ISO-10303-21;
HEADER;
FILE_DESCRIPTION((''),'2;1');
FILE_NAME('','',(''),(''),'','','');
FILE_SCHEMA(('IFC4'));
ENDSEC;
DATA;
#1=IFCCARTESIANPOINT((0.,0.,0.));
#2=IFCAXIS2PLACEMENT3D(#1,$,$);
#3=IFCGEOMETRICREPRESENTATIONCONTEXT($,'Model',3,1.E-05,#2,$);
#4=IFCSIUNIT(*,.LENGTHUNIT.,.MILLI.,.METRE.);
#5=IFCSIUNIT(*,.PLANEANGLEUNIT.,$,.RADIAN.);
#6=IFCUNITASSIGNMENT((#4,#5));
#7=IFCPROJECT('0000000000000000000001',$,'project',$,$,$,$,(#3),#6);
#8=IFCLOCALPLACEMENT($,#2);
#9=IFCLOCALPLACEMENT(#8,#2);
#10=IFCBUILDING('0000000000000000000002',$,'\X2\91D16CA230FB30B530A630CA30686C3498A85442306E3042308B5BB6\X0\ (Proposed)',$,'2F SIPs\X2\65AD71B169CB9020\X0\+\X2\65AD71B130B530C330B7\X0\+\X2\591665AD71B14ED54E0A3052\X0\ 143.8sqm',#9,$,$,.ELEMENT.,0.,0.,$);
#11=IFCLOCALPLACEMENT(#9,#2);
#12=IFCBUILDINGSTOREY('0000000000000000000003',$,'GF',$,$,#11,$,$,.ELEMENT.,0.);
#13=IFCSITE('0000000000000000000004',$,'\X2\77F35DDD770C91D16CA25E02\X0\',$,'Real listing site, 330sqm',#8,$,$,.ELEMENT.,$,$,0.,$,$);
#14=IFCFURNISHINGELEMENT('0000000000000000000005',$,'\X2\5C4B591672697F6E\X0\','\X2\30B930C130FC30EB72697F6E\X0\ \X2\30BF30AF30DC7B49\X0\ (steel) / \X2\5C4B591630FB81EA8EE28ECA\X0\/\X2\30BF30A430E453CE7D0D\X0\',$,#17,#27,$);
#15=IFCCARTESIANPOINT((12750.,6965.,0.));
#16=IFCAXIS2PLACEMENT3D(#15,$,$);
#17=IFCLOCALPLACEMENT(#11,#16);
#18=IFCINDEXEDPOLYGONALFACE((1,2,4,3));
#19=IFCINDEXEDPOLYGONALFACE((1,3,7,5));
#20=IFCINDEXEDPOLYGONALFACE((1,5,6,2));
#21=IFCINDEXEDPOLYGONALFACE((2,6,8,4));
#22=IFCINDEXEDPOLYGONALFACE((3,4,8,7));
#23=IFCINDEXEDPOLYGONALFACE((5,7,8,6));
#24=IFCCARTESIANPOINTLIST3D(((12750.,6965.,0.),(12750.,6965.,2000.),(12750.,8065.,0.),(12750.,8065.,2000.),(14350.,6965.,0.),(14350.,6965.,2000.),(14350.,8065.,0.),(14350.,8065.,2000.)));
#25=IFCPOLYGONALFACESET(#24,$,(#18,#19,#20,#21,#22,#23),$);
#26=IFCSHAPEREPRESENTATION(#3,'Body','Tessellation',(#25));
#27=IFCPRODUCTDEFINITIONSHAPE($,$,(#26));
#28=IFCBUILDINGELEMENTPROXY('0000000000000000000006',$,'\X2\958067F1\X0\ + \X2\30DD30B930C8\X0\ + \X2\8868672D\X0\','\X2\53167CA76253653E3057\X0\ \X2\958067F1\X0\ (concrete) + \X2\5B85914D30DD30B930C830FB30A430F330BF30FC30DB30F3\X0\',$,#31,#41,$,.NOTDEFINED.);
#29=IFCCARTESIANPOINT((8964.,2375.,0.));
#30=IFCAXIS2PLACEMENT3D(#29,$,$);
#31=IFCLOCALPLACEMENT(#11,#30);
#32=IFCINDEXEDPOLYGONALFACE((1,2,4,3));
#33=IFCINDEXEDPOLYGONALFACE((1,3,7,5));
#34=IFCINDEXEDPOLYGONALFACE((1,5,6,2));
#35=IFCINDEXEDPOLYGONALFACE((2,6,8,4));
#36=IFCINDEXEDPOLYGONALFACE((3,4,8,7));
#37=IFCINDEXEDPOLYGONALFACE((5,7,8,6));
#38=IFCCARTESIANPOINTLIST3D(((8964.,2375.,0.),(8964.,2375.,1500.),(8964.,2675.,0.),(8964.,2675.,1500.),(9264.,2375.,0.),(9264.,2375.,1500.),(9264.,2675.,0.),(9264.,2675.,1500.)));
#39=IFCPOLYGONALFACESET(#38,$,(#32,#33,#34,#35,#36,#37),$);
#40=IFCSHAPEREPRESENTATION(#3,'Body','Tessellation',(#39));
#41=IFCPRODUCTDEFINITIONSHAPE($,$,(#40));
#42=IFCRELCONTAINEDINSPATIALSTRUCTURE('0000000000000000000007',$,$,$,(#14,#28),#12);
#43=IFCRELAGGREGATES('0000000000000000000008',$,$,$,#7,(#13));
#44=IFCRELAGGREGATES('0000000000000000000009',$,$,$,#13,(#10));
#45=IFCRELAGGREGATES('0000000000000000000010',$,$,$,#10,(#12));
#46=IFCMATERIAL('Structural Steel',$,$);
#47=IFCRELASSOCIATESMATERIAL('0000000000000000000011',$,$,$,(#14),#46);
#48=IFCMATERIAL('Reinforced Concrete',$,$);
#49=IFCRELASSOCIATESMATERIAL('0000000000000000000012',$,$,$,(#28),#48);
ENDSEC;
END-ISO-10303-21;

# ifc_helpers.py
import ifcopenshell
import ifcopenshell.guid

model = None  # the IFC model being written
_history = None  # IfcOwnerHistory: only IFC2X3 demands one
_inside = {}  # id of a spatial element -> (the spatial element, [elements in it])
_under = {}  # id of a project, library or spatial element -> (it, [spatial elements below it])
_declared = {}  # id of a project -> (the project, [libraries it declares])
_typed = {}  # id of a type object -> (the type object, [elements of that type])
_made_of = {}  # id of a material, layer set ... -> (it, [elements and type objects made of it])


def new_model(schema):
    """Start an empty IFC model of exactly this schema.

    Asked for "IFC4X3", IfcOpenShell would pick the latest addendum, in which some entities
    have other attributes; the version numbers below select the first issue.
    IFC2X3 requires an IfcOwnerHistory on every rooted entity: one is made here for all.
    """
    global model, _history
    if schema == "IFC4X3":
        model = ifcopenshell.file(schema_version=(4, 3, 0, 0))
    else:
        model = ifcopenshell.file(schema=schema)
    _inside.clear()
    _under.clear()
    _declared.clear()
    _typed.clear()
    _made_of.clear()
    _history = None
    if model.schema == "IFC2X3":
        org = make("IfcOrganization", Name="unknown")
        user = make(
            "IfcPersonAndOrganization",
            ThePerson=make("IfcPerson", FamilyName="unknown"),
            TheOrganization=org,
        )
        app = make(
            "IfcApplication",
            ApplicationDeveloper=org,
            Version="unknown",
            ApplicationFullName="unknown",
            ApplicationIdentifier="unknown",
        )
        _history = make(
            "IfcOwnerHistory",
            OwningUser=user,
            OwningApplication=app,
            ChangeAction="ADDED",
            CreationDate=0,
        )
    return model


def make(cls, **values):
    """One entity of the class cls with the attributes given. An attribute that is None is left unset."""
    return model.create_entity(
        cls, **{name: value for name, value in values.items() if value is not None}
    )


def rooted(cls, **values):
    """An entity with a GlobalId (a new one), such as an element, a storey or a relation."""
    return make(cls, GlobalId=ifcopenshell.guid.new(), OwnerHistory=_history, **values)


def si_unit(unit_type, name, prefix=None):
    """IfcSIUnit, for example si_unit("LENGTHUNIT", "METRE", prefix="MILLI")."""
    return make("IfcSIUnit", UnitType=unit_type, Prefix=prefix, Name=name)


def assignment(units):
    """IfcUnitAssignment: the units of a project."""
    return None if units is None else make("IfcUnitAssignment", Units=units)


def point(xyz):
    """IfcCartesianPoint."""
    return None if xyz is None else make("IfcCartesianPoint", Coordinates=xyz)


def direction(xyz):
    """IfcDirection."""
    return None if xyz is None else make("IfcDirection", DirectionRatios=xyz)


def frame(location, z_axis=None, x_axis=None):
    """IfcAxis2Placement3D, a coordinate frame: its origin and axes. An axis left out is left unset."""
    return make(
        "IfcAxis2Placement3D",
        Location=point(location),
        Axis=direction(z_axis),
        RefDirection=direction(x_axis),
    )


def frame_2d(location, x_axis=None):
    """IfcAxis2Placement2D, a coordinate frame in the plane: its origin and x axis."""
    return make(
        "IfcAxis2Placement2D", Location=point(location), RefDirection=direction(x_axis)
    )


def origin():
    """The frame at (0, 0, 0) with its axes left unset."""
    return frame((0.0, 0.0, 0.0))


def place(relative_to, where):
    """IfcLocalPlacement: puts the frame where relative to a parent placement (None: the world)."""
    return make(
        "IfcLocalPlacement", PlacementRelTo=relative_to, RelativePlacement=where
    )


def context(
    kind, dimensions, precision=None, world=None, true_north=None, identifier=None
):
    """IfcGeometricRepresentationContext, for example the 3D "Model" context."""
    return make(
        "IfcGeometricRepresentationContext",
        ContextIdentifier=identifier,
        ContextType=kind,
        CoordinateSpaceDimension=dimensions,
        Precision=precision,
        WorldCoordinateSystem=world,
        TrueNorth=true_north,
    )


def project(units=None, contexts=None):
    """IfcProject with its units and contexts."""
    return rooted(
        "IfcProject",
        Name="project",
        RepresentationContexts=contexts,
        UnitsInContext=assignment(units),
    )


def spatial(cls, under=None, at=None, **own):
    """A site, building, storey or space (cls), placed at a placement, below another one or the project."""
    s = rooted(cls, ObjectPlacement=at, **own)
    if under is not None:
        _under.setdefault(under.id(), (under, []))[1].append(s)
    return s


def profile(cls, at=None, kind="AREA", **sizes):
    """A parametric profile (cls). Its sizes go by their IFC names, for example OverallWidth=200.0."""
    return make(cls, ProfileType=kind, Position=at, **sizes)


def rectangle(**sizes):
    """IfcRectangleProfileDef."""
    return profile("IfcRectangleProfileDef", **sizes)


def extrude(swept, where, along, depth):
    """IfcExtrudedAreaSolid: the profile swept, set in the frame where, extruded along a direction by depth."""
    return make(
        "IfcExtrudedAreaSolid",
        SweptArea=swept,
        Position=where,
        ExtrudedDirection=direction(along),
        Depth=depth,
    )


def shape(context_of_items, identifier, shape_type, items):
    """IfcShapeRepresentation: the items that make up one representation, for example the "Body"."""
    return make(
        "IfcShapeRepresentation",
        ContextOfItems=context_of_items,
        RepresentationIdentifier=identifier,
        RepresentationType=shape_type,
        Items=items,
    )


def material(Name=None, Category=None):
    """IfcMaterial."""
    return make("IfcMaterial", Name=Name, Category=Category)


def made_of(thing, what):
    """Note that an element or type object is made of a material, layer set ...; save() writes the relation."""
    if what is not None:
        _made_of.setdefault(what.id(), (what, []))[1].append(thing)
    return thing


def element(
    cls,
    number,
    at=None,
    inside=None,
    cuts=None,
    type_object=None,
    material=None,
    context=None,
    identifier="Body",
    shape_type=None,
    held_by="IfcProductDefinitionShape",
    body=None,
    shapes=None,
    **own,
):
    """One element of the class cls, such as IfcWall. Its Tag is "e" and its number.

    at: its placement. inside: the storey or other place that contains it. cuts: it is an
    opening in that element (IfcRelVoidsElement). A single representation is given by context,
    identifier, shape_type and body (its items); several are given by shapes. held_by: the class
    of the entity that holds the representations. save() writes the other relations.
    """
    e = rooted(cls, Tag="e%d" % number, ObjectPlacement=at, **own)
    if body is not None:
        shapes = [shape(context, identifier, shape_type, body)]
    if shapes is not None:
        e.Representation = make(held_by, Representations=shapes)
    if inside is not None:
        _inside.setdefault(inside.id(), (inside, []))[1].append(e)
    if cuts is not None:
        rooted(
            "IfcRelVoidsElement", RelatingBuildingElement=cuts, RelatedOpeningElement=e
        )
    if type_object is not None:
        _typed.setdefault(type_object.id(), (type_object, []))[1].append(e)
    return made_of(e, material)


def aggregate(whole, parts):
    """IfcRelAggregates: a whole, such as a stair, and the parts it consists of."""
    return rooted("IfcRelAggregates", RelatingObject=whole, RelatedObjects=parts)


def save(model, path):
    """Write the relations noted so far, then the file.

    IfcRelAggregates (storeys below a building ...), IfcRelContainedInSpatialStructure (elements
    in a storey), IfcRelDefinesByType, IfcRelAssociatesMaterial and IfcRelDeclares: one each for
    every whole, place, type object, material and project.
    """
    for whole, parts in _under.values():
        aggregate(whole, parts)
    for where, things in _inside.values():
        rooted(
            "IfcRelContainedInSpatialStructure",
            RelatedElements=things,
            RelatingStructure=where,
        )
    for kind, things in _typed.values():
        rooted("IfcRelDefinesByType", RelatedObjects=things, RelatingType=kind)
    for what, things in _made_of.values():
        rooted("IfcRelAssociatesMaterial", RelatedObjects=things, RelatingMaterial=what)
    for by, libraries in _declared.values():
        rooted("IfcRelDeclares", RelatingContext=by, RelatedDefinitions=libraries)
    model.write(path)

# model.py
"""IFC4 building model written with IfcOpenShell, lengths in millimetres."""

from ifc_helpers import new_model, si_unit, frame, frame_2d, origin, place, context, project, spatial, rectangle, extrude, material, element, save


model = new_model("IFC4")

# Units and contexts
model_context = context("Model", 3, precision=1e-05, world=origin())
ifc_project = project(units=[si_unit("LENGTHUNIT", "METRE", prefix="MILLI"), si_unit("PLANEANGLEUNIT", "RADIAN")], contexts=[model_context])

# Site, building, storey
site_placement = place(None, origin())
site = spatial("IfcSite", under=ifc_project, at=site_placement, Name="石川県金沢市", ObjectType="Real listing site, 330sqm", CompositionType="ELEMENT", RefElevation=0.0)
building_placement = place(site_placement, origin())
building = spatial("IfcBuilding", under=site, at=building_placement, Name="金沢・サウナと水風呂のある家 (Proposed)", ObjectType="2F SIPs断熱構造+断熱サッシ+外断熱仕上げ 143.8sqm", CompositionType="ELEMENT", ElevationOfRefHeight=0.0, ElevationOfTerrain=0.0)
storey_placement = place(building_placement, origin())
storey = spatial("IfcBuildingStorey", under=building, at=storey_placement, Name="GF", CompositionType="ELEMENT", Elevation=0.0)

# Shared definitions
ifc_material_1 = material(Name="Reinforced Concrete")

# Shared definitions
ifc_material_2 = material(Name="Structural Steel")

# Furnishing element
furnishing_1_placement = place(storey_placement, frame((12750.0, 6965.0, 0.0)))
element("IfcFurnishingElement", 1, at=furnishing_1_placement, inside=storey, material=ifc_material_2, Name="屋外物置", Description="スチール物置 タクボ等 (steel) / 屋外・自転車/タイヤ収納", context=model_context, shape_type="SweptSolid", body=[
    extrude(rectangle(XDim=1600.0, YDim=1100.0, at=frame_2d((800.0, 550.0))), frame((12750.0, 6965.0, 0.0)), (0.0, 0.0, 1.0), 2000.0),
])

# Building element proxy
proxy_placement = place(storey_placement, frame((8964.0, 2375.0, 0.0)))
element("IfcBuildingElementProxy", 2, at=proxy_placement, inside=storey, material=ifc_material_1, Name="門柱 + ポスト + 表札", Description="化粧打放し 門柱 (concrete) + 宅配ポスト・インターホン", PredefinedType="NOTDEFINED", context=model_context, shape_type="SweptSolid", body=[
    extrude(rectangle(XDim=300.0, YDim=300.0, at=frame_2d((150.0, 150.0))), frame((8964.0, 2375.0, 0.0)), (0.0, 0.0, 1.0), 1500.0),
])

save(model, "model.ifc")
